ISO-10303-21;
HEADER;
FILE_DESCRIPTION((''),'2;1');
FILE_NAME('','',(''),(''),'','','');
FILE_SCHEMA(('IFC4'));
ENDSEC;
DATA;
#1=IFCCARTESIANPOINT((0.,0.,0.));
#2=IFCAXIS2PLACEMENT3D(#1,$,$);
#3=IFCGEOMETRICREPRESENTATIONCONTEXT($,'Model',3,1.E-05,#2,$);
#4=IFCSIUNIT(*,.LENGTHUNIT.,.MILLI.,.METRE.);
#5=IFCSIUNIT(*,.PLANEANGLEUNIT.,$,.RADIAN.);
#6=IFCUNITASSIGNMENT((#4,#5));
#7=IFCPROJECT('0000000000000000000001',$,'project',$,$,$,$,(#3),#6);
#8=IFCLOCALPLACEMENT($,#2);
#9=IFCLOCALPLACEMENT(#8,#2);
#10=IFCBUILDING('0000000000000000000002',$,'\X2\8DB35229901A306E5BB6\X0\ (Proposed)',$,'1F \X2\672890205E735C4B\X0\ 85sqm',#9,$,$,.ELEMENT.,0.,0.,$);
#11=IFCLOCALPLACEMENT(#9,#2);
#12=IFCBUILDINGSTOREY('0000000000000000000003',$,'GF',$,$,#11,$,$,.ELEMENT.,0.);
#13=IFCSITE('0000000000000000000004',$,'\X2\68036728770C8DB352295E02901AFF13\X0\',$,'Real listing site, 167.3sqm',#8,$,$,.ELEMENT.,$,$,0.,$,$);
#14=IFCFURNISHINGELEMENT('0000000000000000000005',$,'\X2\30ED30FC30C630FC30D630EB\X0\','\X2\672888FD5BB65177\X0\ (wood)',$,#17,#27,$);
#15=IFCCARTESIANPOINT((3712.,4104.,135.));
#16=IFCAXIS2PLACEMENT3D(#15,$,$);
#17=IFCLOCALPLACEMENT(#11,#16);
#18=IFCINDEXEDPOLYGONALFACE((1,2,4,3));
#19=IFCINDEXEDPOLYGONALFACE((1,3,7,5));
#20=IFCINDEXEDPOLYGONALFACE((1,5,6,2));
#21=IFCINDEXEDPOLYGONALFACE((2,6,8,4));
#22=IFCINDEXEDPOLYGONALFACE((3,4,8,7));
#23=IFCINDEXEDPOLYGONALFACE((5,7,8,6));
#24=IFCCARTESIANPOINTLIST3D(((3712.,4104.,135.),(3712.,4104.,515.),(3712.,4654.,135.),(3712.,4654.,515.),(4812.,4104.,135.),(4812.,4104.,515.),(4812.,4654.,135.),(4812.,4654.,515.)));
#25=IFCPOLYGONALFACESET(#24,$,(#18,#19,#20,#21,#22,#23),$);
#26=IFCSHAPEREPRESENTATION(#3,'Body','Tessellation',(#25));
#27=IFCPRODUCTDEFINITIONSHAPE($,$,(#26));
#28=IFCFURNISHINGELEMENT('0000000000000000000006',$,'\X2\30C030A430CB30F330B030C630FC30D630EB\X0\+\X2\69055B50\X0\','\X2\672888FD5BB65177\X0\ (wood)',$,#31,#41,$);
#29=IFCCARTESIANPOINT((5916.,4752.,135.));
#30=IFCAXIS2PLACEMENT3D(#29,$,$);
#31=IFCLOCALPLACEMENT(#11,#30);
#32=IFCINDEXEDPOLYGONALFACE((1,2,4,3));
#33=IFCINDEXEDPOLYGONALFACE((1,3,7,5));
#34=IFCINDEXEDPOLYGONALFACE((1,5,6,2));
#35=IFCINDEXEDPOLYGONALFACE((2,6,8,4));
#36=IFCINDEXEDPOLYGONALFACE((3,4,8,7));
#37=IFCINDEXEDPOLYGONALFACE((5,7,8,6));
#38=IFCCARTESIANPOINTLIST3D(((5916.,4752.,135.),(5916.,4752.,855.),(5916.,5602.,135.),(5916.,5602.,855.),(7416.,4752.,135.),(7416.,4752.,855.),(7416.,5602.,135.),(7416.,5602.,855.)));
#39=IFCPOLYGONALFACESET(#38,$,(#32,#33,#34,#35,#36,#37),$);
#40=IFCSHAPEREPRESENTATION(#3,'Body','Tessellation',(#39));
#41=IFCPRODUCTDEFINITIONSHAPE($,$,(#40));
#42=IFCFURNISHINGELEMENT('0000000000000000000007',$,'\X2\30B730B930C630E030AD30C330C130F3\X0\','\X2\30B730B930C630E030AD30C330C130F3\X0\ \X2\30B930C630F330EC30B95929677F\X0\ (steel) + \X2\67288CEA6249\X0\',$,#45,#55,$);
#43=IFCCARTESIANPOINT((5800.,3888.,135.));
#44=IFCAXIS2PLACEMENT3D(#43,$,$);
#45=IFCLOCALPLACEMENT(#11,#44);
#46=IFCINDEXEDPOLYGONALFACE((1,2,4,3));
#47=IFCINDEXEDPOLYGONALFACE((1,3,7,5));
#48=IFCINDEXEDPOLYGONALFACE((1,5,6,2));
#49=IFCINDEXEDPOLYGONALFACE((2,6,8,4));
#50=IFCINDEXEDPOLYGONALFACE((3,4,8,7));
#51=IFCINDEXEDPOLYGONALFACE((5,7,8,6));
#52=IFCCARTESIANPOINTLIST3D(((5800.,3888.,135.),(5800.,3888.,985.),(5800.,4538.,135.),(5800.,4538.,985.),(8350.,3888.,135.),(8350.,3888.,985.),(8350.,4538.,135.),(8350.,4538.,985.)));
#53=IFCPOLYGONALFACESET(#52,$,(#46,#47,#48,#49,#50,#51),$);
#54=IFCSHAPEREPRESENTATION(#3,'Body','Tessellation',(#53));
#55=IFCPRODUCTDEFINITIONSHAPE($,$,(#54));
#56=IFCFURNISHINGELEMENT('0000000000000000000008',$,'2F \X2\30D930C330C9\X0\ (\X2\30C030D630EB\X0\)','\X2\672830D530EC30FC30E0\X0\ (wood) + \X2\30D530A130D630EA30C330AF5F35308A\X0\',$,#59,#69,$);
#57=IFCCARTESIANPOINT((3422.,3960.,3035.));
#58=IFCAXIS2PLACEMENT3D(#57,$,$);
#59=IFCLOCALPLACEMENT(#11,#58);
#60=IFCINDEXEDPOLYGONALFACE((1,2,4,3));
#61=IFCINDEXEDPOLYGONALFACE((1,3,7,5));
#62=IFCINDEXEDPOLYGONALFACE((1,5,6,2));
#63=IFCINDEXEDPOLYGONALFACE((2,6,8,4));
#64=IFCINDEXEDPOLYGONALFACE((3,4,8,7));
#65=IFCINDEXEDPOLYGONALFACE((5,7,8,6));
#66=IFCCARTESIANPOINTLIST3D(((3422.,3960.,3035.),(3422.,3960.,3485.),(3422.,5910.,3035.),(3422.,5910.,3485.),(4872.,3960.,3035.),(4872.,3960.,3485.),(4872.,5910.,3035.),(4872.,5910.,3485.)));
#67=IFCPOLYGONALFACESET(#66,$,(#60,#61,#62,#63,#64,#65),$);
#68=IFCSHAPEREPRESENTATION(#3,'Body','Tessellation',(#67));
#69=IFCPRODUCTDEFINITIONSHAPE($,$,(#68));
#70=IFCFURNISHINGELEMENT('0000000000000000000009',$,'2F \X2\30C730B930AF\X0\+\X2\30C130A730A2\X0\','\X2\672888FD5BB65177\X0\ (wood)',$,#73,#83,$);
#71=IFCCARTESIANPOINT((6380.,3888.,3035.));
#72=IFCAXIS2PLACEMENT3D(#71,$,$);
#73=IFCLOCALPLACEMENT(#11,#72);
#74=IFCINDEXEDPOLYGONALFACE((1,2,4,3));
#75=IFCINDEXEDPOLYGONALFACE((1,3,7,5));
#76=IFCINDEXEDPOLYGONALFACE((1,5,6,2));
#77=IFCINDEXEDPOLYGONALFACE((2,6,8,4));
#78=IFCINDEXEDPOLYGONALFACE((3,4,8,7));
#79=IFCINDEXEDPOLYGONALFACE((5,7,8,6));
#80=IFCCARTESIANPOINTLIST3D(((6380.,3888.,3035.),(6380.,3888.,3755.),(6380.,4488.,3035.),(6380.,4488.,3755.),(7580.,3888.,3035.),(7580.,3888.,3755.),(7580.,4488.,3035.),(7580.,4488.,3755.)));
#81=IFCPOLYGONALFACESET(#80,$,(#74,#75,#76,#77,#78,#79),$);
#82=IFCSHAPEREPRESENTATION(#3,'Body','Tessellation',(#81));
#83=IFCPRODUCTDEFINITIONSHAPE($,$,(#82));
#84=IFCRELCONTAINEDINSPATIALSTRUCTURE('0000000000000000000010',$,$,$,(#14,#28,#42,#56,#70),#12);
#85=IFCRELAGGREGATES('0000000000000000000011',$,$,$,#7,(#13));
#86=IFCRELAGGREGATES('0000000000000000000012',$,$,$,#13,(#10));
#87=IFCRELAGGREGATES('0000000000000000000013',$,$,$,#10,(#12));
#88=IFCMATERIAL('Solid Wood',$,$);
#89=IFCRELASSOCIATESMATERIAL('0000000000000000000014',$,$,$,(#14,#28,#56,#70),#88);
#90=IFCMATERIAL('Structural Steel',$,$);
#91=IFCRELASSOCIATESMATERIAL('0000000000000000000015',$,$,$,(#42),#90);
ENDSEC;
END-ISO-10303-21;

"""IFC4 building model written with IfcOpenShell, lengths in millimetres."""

from ifc_helpers import new_model, si_unit, frame, frame_2d, origin, place, context, project, spatial, rectangle, extrude, material, element, save


model = new_model("IFC4")

# Units and contexts
model_context = context("Model", 3, precision=1e-05, world=origin())
ifc_project = project(units=[si_unit("LENGTHUNIT", "METRE", prefix="MILLI"), si_unit("PLANEANGLEUNIT", "RADIAN")], contexts=[model_context])

# Site, building, storey
site_placement = place(None, origin())
site = spatial("IfcSite", under=ifc_project, at=site_placement, Name="栃木県足利市通３", ObjectType="Real listing site, 167.3sqm", CompositionType="ELEMENT", RefElevation=0.0)
building_placement = place(site_placement, origin())
building = spatial("IfcBuilding", under=site, at=building_placement, Name="足利通の家 (Proposed)", ObjectType="1F 木造平屋 85sqm", CompositionType="ELEMENT", ElevationOfRefHeight=0.0, ElevationOfTerrain=0.0)
storey_placement = place(building_placement, origin())
storey = spatial("IfcBuildingStorey", under=building, at=storey_placement, Name="GF", CompositionType="ELEMENT", Elevation=0.0)

# Shared definitions
ifc_material_1 = material(Name="Solid Wood")

# Shared definitions
ifc_material_2 = material(Name="Structural Steel")

# Furnishing elements
furnishing_1_placement = place(storey_placement, frame((3712.0, 4104.0, 135.0)))
element("IfcFurnishingElement", 1, at=furnishing_1_placement, inside=storey, material=ifc_material_1, Name="ローテーブル", Description="木製家具 (wood)", context=model_context, shape_type="SweptSolid", body=[
    extrude(rectangle(XDim=1100.0, YDim=550.0, at=frame_2d((550.0, 275.0))), frame((3712.0, 4104.0, 135.0)), (0.0, 0.0, 1.0), 380.0),
])
furnishing_2_placement = place(storey_placement, frame((5916.0, 4752.0, 135.0)))
element("IfcFurnishingElement", 2, at=furnishing_2_placement, inside=storey, material=ifc_material_1, Name="ダイニングテーブル+椅子", Description="木製家具 (wood)", context=model_context, shape_type="SweptSolid", body=[
    extrude(rectangle(XDim=1500.0, YDim=850.0, at=frame_2d((750.0, 425.0))), frame((5916.0, 4752.0, 135.0)), (0.0, 0.0, 1.0), 720.0),
])
furnishing_3_placement = place(storey_placement, frame((5800.0, 3888.0, 135.0)))
element("IfcFurnishingElement", 3, at=furnishing_3_placement, inside=storey, material=ifc_material_2, Name="システムキッチン", Description="システムキッチン ステンレス天板 (steel) + 木質扉", context=model_context, shape_type="SweptSolid", body=[
    extrude(rectangle(XDim=2550.0, YDim=650.0, at=frame_2d((1275.0, 325.0))), frame((5800.0, 3888.0, 135.0)), (0.0, 0.0, 1.0), 850.0),
])
furnishing_4_placement = place(storey_placement, frame((3422.0, 3960.0, 3035.0)))
element("IfcFurnishingElement", 4, at=furnishing_4_placement, inside=storey, material=ifc_material_1, Name="2F ベッド (ダブル)", Description="木フレーム (wood) + ファブリック張り", context=model_context, shape_type="SweptSolid", body=[
    extrude(rectangle(XDim=1450.0, YDim=1950.0, at=frame_2d((725.0, 975.0))), frame((3422.0, 3960.0, 3035.0)), (0.0, 0.0, 1.0), 450.0),
])
furnishing_5_placement = place(storey_placement, frame((6380.0, 3888.0, 3035.0)))
element("IfcFurnishingElement", 5, at=furnishing_5_placement, inside=storey, material=ifc_material_1, Name="2F デスク+チェア", Description="木製家具 (wood)", context=model_context, shape_type="SweptSolid", body=[
    extrude(rectangle(XDim=1200.0, YDim=600.0, at=frame_2d((600.0, 300.0))), frame((6380.0, 3888.0, 3035.0)), (0.0, 0.0, 1.0), 720.0),
])

save(model, "model.ifc")
